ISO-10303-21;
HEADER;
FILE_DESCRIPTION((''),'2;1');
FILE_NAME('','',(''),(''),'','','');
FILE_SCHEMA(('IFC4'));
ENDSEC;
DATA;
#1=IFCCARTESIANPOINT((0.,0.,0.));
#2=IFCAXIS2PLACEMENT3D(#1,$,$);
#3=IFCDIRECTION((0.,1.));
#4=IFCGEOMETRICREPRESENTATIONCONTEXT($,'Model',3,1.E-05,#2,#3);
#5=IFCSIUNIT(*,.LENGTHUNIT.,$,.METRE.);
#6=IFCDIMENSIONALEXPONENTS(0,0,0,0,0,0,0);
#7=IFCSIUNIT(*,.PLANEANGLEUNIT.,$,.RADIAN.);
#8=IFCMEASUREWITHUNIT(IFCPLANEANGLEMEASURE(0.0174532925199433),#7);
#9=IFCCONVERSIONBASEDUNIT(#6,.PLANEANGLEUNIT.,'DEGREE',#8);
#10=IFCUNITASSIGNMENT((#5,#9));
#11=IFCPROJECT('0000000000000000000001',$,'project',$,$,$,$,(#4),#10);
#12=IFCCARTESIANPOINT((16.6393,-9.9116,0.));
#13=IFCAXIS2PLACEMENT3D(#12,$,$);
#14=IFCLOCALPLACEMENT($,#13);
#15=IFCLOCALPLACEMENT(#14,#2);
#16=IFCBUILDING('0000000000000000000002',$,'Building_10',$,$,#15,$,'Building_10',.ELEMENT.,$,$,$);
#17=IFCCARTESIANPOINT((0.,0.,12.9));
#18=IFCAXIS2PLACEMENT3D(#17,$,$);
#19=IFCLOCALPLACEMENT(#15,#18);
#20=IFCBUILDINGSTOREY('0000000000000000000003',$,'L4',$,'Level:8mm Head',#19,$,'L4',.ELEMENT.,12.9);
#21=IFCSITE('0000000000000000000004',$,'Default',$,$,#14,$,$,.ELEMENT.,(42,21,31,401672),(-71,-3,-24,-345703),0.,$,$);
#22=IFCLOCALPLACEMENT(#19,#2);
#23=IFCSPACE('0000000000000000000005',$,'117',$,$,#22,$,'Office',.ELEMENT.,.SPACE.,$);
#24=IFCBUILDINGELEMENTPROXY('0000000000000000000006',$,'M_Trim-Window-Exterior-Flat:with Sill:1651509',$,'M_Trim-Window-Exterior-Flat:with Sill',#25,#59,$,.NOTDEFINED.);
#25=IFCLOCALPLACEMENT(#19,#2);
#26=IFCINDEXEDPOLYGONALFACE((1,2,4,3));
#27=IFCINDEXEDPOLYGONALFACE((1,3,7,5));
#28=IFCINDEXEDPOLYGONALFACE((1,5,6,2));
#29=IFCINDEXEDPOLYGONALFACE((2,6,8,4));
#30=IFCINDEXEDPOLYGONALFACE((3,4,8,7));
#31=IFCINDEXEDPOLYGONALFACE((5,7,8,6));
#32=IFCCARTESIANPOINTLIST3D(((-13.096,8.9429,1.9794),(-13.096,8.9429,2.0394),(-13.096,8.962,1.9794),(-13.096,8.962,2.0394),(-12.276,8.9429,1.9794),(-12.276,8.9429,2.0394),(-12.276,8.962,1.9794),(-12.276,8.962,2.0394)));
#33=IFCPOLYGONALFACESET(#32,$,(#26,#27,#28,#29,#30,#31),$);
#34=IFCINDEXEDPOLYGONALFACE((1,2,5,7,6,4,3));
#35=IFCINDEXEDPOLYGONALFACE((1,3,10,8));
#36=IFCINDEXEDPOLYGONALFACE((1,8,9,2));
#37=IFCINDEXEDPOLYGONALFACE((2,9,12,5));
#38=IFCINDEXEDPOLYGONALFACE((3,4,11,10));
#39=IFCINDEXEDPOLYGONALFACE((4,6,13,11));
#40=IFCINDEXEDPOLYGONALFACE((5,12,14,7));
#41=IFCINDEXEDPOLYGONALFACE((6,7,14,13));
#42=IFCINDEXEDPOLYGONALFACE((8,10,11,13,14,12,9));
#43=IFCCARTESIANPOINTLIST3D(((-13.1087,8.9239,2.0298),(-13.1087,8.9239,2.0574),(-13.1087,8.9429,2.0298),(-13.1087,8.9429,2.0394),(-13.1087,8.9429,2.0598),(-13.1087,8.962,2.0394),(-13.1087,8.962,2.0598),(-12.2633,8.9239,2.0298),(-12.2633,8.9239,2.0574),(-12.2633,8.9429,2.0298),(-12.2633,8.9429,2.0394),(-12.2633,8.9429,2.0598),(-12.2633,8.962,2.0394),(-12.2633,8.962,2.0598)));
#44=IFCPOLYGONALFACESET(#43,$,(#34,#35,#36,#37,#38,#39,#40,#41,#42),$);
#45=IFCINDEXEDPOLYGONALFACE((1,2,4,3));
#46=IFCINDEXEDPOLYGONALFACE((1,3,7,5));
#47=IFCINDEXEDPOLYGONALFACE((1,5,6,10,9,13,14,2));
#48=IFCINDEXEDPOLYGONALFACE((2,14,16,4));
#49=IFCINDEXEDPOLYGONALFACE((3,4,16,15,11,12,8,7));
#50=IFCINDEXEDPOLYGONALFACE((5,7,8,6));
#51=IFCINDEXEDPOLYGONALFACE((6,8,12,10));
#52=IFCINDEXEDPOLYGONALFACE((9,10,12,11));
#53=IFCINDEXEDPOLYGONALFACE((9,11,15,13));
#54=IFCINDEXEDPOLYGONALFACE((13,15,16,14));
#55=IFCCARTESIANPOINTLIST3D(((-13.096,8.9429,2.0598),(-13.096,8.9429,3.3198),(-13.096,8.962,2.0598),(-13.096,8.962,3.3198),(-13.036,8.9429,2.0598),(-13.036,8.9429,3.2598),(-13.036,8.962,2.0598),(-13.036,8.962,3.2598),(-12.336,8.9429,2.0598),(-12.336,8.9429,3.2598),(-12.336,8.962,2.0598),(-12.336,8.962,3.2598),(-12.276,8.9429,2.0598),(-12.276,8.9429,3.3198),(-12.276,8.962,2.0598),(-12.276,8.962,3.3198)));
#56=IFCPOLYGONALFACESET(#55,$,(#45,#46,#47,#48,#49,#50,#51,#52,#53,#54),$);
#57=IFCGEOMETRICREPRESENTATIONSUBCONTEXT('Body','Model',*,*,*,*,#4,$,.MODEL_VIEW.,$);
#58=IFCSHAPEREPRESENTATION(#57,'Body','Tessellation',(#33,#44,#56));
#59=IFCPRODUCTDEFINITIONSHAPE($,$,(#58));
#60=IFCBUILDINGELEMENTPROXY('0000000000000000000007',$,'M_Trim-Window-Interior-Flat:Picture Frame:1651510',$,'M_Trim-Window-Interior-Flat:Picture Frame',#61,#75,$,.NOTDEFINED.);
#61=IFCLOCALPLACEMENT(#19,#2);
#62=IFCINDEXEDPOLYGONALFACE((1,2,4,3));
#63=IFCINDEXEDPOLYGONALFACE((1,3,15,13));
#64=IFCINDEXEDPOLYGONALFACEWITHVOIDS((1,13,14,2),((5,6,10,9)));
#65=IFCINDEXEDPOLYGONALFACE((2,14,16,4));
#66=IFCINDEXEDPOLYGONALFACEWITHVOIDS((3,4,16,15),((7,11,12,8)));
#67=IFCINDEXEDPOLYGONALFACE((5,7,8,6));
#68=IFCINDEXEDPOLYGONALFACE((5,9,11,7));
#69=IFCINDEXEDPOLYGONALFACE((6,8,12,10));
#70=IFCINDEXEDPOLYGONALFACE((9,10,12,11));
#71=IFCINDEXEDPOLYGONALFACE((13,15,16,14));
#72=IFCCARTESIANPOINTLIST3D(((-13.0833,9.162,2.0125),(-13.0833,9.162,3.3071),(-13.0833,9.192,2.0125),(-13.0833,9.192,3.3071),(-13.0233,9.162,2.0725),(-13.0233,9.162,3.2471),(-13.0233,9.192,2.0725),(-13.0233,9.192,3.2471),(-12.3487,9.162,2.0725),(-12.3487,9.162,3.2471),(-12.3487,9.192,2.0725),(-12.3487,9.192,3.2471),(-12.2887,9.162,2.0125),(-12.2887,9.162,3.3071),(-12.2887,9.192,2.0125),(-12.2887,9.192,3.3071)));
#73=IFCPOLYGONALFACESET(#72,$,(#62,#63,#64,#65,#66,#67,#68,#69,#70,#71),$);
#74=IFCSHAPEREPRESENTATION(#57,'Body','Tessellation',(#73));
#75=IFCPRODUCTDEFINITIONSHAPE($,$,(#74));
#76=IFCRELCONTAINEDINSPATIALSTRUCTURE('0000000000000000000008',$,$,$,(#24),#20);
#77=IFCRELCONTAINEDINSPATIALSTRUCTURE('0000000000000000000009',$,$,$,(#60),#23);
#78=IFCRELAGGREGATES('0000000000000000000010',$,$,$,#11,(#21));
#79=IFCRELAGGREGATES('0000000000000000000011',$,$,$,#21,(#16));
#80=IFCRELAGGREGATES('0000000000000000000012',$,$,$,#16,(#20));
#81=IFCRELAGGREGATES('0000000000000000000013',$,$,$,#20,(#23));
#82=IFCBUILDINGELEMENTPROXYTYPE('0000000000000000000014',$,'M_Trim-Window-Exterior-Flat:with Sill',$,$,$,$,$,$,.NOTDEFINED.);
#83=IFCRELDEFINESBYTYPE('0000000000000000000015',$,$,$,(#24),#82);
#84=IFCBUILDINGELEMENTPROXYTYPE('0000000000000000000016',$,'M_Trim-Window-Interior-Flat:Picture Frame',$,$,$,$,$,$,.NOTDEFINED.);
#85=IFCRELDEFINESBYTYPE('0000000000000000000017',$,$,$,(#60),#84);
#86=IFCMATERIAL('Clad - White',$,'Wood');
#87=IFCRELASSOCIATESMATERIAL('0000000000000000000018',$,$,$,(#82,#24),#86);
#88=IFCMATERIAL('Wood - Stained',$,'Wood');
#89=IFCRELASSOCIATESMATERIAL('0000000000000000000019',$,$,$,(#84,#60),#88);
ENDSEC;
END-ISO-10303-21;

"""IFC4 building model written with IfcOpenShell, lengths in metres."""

from ifc_helpers import new_model, entity, si_unit, converted_unit, direction, frame, origin, place, context, subcontext, project, spatial, indexed_curve, outline, extrude, source, transform, mapped, material, type_object, type_shapes, element, save


model = new_model("IFC4")

# Units and contexts
model_context = context("Model", 3, precision=1e-05, world=origin(), true_north=direction((0.0, 1.0)))
body_context = subcontext(model_context, "Body", "Model", "MODEL_VIEW")
ifc_project = project(units=[si_unit("LENGTHUNIT", "METRE"), converted_unit("PLANEANGLEUNIT", "DEGREE", entity("IfcPlaneAngleMeasure", 0.0174532925199433), si_unit("PLANEANGLEUNIT", "RADIAN"), dimensions=[0, 0, 0, 0, 0, 0, 0])], contexts=[model_context])

# Site, building, storey
site_placement = place(None, frame((16.6393, -9.9116, 0.0)))
site = spatial("IfcSite", under=ifc_project, at=site_placement, Name="Default", CompositionType="ELEMENT", RefLatitude=(42, 21, 31, 401672), RefLongitude=(-71, -3, -24, -345703), RefElevation=0.0)
building_placement = place(site_placement, origin())
building = spatial("IfcBuilding", under=site, at=building_placement, Name="Building_10", LongName="Building_10", CompositionType="ELEMENT")
storey_placement = place(building_placement, frame((0.0, 0.0, 12.9)))
storey = spatial("IfcBuildingStorey", under=building, at=storey_placement, Name="L4", ObjectType="Level:8mm Head", LongName="L4", CompositionType="ELEMENT", Elevation=12.9)

# Building element proxy
ifc_material_1 = material(Name="Clad - White", Category="Wood")
ifc_material_2 = material(Name="Wood - Stained", Category="Wood")
building_element_proxy_type_1 = type_object("IfcBuildingElementProxyType", Name="M_Trim-Window-Exterior-Flat:with Sill", PredefinedType="NOTDEFINED", material=ifc_material_1)
shared_shape_1 = source(origin(), body_context, "Body", "SweptSolid", [
    extrude(outline(indexed_curve([(-0.41, -0.03), (0.41, -0.03), (0.41, 0.03), (-0.41, 0.03), (-0.41, -0.03)], self_intersect=False)), frame((0.0, -1.2504, 0.0), z_axis=(0.0, 0.0, 1.0), x_axis=(-1.0, 0.0, 0.0)), (0.0, 0.0, 1.0), 0.0191),
    extrude(outline(indexed_curve([(-0.019, -0.0152), (0.0, -0.0152), (0.0, -0.0057), (0.019, -0.0057), (0.019, 0.0148), (0.0, 0.0148), (-0.019, 0.0123), (-0.019, -0.0152)], self_intersect=False)), frame((-0.4227, -1.2148, 0.019), z_axis=(1.0, 0.0, 0.0), x_axis=(0.0, 0.0, -1.0)), (0.0, 0.0, 1.0), 0.8454),
    extrude(outline(indexed_curve([(-0.645, -0.41), (0.615, -0.41), (0.615, -0.35), (-0.585, -0.35), (-0.585, 0.35), (0.615, 0.35), (0.615, 0.41), (-0.645, 0.41), (-0.645, -0.41)], self_intersect=False)), frame((0.0, -0.585, 0.0), z_axis=(0.0, 0.0, 1.0), x_axis=(0.0, -1.0, 0.0)), (0.0, 0.0, 1.0), 0.0191),
])
type_shapes(building_element_proxy_type_1, [shared_shape_1])
proxy_1_placement = place(storey_placement, frame((-12.686, 8.962, 3.2598), z_axis=(0.0, -1.0, 0.0), x_axis=(1.0, 0.0, 0.0)))
element("IfcBuildingElementProxy", 1, at=proxy_1_placement, inside=storey, type_object=building_element_proxy_type_1, material=ifc_material_1, Name="M_Trim-Window-Exterior-Flat:with Sill:1651509", ObjectType="M_Trim-Window-Exterior-Flat:with Sill", PredefinedType="NOTDEFINED", context=body_context, shape_type="MappedRepresentation", body=[
    mapped(shared_shape_1, transform((0.0, 0.0, 0.0), scale=1.0)),
])

# Shared definitions
space_placement = place(storey_placement, origin())
space = spatial("IfcSpace", under=storey, at=space_placement, Name="117", LongName="Office", CompositionType="ELEMENT", PredefinedType="SPACE")

# Building element proxy
building_element_proxy_type_2 = type_object("IfcBuildingElementProxyType", Name="M_Trim-Window-Interior-Flat:Picture Frame", PredefinedType="NOTDEFINED", material=ifc_material_2)
shared_shape_2 = source(origin(), body_context, "Body", "SweptSolid", [
    extrude(outline(indexed_curve([(-0.3973, -0.6473), (0.3973, -0.6473), (0.3973, 0.6473), (-0.3973, 0.6473), (-0.3973, -0.6473)], self_intersect=False), holes=[indexed_curve([(-0.3373, -0.5873), (-0.3373, 0.5873), (0.3373, 0.5873), (0.3373, -0.5873), (-0.3373, -0.5873)], self_intersect=False)]), frame((0.0, -0.6, 0.0), z_axis=(0.0, 0.0, 1.0), x_axis=(-1.0, 0.0, 0.0)), (0.0, 0.0, 1.0), 0.03),
])
type_shapes(building_element_proxy_type_2, [shared_shape_2])
proxy_2_placement = place(space_placement, frame((-12.686, 9.162, 3.2598), z_axis=(0.0, 1.0, 0.0), x_axis=(-1.0, 0.0, 0.0)))
element("IfcBuildingElementProxy", 2, at=proxy_2_placement, inside=space, type_object=building_element_proxy_type_2, material=ifc_material_2, Name="M_Trim-Window-Interior-Flat:Picture Frame:1651510", ObjectType="M_Trim-Window-Interior-Flat:Picture Frame", PredefinedType="NOTDEFINED", context=body_context, shape_type="MappedRepresentation", body=[
    mapped(shared_shape_2, transform((0.0, 0.0, 0.0), scale=1.0)),
])

save(model, "model.ifc")
